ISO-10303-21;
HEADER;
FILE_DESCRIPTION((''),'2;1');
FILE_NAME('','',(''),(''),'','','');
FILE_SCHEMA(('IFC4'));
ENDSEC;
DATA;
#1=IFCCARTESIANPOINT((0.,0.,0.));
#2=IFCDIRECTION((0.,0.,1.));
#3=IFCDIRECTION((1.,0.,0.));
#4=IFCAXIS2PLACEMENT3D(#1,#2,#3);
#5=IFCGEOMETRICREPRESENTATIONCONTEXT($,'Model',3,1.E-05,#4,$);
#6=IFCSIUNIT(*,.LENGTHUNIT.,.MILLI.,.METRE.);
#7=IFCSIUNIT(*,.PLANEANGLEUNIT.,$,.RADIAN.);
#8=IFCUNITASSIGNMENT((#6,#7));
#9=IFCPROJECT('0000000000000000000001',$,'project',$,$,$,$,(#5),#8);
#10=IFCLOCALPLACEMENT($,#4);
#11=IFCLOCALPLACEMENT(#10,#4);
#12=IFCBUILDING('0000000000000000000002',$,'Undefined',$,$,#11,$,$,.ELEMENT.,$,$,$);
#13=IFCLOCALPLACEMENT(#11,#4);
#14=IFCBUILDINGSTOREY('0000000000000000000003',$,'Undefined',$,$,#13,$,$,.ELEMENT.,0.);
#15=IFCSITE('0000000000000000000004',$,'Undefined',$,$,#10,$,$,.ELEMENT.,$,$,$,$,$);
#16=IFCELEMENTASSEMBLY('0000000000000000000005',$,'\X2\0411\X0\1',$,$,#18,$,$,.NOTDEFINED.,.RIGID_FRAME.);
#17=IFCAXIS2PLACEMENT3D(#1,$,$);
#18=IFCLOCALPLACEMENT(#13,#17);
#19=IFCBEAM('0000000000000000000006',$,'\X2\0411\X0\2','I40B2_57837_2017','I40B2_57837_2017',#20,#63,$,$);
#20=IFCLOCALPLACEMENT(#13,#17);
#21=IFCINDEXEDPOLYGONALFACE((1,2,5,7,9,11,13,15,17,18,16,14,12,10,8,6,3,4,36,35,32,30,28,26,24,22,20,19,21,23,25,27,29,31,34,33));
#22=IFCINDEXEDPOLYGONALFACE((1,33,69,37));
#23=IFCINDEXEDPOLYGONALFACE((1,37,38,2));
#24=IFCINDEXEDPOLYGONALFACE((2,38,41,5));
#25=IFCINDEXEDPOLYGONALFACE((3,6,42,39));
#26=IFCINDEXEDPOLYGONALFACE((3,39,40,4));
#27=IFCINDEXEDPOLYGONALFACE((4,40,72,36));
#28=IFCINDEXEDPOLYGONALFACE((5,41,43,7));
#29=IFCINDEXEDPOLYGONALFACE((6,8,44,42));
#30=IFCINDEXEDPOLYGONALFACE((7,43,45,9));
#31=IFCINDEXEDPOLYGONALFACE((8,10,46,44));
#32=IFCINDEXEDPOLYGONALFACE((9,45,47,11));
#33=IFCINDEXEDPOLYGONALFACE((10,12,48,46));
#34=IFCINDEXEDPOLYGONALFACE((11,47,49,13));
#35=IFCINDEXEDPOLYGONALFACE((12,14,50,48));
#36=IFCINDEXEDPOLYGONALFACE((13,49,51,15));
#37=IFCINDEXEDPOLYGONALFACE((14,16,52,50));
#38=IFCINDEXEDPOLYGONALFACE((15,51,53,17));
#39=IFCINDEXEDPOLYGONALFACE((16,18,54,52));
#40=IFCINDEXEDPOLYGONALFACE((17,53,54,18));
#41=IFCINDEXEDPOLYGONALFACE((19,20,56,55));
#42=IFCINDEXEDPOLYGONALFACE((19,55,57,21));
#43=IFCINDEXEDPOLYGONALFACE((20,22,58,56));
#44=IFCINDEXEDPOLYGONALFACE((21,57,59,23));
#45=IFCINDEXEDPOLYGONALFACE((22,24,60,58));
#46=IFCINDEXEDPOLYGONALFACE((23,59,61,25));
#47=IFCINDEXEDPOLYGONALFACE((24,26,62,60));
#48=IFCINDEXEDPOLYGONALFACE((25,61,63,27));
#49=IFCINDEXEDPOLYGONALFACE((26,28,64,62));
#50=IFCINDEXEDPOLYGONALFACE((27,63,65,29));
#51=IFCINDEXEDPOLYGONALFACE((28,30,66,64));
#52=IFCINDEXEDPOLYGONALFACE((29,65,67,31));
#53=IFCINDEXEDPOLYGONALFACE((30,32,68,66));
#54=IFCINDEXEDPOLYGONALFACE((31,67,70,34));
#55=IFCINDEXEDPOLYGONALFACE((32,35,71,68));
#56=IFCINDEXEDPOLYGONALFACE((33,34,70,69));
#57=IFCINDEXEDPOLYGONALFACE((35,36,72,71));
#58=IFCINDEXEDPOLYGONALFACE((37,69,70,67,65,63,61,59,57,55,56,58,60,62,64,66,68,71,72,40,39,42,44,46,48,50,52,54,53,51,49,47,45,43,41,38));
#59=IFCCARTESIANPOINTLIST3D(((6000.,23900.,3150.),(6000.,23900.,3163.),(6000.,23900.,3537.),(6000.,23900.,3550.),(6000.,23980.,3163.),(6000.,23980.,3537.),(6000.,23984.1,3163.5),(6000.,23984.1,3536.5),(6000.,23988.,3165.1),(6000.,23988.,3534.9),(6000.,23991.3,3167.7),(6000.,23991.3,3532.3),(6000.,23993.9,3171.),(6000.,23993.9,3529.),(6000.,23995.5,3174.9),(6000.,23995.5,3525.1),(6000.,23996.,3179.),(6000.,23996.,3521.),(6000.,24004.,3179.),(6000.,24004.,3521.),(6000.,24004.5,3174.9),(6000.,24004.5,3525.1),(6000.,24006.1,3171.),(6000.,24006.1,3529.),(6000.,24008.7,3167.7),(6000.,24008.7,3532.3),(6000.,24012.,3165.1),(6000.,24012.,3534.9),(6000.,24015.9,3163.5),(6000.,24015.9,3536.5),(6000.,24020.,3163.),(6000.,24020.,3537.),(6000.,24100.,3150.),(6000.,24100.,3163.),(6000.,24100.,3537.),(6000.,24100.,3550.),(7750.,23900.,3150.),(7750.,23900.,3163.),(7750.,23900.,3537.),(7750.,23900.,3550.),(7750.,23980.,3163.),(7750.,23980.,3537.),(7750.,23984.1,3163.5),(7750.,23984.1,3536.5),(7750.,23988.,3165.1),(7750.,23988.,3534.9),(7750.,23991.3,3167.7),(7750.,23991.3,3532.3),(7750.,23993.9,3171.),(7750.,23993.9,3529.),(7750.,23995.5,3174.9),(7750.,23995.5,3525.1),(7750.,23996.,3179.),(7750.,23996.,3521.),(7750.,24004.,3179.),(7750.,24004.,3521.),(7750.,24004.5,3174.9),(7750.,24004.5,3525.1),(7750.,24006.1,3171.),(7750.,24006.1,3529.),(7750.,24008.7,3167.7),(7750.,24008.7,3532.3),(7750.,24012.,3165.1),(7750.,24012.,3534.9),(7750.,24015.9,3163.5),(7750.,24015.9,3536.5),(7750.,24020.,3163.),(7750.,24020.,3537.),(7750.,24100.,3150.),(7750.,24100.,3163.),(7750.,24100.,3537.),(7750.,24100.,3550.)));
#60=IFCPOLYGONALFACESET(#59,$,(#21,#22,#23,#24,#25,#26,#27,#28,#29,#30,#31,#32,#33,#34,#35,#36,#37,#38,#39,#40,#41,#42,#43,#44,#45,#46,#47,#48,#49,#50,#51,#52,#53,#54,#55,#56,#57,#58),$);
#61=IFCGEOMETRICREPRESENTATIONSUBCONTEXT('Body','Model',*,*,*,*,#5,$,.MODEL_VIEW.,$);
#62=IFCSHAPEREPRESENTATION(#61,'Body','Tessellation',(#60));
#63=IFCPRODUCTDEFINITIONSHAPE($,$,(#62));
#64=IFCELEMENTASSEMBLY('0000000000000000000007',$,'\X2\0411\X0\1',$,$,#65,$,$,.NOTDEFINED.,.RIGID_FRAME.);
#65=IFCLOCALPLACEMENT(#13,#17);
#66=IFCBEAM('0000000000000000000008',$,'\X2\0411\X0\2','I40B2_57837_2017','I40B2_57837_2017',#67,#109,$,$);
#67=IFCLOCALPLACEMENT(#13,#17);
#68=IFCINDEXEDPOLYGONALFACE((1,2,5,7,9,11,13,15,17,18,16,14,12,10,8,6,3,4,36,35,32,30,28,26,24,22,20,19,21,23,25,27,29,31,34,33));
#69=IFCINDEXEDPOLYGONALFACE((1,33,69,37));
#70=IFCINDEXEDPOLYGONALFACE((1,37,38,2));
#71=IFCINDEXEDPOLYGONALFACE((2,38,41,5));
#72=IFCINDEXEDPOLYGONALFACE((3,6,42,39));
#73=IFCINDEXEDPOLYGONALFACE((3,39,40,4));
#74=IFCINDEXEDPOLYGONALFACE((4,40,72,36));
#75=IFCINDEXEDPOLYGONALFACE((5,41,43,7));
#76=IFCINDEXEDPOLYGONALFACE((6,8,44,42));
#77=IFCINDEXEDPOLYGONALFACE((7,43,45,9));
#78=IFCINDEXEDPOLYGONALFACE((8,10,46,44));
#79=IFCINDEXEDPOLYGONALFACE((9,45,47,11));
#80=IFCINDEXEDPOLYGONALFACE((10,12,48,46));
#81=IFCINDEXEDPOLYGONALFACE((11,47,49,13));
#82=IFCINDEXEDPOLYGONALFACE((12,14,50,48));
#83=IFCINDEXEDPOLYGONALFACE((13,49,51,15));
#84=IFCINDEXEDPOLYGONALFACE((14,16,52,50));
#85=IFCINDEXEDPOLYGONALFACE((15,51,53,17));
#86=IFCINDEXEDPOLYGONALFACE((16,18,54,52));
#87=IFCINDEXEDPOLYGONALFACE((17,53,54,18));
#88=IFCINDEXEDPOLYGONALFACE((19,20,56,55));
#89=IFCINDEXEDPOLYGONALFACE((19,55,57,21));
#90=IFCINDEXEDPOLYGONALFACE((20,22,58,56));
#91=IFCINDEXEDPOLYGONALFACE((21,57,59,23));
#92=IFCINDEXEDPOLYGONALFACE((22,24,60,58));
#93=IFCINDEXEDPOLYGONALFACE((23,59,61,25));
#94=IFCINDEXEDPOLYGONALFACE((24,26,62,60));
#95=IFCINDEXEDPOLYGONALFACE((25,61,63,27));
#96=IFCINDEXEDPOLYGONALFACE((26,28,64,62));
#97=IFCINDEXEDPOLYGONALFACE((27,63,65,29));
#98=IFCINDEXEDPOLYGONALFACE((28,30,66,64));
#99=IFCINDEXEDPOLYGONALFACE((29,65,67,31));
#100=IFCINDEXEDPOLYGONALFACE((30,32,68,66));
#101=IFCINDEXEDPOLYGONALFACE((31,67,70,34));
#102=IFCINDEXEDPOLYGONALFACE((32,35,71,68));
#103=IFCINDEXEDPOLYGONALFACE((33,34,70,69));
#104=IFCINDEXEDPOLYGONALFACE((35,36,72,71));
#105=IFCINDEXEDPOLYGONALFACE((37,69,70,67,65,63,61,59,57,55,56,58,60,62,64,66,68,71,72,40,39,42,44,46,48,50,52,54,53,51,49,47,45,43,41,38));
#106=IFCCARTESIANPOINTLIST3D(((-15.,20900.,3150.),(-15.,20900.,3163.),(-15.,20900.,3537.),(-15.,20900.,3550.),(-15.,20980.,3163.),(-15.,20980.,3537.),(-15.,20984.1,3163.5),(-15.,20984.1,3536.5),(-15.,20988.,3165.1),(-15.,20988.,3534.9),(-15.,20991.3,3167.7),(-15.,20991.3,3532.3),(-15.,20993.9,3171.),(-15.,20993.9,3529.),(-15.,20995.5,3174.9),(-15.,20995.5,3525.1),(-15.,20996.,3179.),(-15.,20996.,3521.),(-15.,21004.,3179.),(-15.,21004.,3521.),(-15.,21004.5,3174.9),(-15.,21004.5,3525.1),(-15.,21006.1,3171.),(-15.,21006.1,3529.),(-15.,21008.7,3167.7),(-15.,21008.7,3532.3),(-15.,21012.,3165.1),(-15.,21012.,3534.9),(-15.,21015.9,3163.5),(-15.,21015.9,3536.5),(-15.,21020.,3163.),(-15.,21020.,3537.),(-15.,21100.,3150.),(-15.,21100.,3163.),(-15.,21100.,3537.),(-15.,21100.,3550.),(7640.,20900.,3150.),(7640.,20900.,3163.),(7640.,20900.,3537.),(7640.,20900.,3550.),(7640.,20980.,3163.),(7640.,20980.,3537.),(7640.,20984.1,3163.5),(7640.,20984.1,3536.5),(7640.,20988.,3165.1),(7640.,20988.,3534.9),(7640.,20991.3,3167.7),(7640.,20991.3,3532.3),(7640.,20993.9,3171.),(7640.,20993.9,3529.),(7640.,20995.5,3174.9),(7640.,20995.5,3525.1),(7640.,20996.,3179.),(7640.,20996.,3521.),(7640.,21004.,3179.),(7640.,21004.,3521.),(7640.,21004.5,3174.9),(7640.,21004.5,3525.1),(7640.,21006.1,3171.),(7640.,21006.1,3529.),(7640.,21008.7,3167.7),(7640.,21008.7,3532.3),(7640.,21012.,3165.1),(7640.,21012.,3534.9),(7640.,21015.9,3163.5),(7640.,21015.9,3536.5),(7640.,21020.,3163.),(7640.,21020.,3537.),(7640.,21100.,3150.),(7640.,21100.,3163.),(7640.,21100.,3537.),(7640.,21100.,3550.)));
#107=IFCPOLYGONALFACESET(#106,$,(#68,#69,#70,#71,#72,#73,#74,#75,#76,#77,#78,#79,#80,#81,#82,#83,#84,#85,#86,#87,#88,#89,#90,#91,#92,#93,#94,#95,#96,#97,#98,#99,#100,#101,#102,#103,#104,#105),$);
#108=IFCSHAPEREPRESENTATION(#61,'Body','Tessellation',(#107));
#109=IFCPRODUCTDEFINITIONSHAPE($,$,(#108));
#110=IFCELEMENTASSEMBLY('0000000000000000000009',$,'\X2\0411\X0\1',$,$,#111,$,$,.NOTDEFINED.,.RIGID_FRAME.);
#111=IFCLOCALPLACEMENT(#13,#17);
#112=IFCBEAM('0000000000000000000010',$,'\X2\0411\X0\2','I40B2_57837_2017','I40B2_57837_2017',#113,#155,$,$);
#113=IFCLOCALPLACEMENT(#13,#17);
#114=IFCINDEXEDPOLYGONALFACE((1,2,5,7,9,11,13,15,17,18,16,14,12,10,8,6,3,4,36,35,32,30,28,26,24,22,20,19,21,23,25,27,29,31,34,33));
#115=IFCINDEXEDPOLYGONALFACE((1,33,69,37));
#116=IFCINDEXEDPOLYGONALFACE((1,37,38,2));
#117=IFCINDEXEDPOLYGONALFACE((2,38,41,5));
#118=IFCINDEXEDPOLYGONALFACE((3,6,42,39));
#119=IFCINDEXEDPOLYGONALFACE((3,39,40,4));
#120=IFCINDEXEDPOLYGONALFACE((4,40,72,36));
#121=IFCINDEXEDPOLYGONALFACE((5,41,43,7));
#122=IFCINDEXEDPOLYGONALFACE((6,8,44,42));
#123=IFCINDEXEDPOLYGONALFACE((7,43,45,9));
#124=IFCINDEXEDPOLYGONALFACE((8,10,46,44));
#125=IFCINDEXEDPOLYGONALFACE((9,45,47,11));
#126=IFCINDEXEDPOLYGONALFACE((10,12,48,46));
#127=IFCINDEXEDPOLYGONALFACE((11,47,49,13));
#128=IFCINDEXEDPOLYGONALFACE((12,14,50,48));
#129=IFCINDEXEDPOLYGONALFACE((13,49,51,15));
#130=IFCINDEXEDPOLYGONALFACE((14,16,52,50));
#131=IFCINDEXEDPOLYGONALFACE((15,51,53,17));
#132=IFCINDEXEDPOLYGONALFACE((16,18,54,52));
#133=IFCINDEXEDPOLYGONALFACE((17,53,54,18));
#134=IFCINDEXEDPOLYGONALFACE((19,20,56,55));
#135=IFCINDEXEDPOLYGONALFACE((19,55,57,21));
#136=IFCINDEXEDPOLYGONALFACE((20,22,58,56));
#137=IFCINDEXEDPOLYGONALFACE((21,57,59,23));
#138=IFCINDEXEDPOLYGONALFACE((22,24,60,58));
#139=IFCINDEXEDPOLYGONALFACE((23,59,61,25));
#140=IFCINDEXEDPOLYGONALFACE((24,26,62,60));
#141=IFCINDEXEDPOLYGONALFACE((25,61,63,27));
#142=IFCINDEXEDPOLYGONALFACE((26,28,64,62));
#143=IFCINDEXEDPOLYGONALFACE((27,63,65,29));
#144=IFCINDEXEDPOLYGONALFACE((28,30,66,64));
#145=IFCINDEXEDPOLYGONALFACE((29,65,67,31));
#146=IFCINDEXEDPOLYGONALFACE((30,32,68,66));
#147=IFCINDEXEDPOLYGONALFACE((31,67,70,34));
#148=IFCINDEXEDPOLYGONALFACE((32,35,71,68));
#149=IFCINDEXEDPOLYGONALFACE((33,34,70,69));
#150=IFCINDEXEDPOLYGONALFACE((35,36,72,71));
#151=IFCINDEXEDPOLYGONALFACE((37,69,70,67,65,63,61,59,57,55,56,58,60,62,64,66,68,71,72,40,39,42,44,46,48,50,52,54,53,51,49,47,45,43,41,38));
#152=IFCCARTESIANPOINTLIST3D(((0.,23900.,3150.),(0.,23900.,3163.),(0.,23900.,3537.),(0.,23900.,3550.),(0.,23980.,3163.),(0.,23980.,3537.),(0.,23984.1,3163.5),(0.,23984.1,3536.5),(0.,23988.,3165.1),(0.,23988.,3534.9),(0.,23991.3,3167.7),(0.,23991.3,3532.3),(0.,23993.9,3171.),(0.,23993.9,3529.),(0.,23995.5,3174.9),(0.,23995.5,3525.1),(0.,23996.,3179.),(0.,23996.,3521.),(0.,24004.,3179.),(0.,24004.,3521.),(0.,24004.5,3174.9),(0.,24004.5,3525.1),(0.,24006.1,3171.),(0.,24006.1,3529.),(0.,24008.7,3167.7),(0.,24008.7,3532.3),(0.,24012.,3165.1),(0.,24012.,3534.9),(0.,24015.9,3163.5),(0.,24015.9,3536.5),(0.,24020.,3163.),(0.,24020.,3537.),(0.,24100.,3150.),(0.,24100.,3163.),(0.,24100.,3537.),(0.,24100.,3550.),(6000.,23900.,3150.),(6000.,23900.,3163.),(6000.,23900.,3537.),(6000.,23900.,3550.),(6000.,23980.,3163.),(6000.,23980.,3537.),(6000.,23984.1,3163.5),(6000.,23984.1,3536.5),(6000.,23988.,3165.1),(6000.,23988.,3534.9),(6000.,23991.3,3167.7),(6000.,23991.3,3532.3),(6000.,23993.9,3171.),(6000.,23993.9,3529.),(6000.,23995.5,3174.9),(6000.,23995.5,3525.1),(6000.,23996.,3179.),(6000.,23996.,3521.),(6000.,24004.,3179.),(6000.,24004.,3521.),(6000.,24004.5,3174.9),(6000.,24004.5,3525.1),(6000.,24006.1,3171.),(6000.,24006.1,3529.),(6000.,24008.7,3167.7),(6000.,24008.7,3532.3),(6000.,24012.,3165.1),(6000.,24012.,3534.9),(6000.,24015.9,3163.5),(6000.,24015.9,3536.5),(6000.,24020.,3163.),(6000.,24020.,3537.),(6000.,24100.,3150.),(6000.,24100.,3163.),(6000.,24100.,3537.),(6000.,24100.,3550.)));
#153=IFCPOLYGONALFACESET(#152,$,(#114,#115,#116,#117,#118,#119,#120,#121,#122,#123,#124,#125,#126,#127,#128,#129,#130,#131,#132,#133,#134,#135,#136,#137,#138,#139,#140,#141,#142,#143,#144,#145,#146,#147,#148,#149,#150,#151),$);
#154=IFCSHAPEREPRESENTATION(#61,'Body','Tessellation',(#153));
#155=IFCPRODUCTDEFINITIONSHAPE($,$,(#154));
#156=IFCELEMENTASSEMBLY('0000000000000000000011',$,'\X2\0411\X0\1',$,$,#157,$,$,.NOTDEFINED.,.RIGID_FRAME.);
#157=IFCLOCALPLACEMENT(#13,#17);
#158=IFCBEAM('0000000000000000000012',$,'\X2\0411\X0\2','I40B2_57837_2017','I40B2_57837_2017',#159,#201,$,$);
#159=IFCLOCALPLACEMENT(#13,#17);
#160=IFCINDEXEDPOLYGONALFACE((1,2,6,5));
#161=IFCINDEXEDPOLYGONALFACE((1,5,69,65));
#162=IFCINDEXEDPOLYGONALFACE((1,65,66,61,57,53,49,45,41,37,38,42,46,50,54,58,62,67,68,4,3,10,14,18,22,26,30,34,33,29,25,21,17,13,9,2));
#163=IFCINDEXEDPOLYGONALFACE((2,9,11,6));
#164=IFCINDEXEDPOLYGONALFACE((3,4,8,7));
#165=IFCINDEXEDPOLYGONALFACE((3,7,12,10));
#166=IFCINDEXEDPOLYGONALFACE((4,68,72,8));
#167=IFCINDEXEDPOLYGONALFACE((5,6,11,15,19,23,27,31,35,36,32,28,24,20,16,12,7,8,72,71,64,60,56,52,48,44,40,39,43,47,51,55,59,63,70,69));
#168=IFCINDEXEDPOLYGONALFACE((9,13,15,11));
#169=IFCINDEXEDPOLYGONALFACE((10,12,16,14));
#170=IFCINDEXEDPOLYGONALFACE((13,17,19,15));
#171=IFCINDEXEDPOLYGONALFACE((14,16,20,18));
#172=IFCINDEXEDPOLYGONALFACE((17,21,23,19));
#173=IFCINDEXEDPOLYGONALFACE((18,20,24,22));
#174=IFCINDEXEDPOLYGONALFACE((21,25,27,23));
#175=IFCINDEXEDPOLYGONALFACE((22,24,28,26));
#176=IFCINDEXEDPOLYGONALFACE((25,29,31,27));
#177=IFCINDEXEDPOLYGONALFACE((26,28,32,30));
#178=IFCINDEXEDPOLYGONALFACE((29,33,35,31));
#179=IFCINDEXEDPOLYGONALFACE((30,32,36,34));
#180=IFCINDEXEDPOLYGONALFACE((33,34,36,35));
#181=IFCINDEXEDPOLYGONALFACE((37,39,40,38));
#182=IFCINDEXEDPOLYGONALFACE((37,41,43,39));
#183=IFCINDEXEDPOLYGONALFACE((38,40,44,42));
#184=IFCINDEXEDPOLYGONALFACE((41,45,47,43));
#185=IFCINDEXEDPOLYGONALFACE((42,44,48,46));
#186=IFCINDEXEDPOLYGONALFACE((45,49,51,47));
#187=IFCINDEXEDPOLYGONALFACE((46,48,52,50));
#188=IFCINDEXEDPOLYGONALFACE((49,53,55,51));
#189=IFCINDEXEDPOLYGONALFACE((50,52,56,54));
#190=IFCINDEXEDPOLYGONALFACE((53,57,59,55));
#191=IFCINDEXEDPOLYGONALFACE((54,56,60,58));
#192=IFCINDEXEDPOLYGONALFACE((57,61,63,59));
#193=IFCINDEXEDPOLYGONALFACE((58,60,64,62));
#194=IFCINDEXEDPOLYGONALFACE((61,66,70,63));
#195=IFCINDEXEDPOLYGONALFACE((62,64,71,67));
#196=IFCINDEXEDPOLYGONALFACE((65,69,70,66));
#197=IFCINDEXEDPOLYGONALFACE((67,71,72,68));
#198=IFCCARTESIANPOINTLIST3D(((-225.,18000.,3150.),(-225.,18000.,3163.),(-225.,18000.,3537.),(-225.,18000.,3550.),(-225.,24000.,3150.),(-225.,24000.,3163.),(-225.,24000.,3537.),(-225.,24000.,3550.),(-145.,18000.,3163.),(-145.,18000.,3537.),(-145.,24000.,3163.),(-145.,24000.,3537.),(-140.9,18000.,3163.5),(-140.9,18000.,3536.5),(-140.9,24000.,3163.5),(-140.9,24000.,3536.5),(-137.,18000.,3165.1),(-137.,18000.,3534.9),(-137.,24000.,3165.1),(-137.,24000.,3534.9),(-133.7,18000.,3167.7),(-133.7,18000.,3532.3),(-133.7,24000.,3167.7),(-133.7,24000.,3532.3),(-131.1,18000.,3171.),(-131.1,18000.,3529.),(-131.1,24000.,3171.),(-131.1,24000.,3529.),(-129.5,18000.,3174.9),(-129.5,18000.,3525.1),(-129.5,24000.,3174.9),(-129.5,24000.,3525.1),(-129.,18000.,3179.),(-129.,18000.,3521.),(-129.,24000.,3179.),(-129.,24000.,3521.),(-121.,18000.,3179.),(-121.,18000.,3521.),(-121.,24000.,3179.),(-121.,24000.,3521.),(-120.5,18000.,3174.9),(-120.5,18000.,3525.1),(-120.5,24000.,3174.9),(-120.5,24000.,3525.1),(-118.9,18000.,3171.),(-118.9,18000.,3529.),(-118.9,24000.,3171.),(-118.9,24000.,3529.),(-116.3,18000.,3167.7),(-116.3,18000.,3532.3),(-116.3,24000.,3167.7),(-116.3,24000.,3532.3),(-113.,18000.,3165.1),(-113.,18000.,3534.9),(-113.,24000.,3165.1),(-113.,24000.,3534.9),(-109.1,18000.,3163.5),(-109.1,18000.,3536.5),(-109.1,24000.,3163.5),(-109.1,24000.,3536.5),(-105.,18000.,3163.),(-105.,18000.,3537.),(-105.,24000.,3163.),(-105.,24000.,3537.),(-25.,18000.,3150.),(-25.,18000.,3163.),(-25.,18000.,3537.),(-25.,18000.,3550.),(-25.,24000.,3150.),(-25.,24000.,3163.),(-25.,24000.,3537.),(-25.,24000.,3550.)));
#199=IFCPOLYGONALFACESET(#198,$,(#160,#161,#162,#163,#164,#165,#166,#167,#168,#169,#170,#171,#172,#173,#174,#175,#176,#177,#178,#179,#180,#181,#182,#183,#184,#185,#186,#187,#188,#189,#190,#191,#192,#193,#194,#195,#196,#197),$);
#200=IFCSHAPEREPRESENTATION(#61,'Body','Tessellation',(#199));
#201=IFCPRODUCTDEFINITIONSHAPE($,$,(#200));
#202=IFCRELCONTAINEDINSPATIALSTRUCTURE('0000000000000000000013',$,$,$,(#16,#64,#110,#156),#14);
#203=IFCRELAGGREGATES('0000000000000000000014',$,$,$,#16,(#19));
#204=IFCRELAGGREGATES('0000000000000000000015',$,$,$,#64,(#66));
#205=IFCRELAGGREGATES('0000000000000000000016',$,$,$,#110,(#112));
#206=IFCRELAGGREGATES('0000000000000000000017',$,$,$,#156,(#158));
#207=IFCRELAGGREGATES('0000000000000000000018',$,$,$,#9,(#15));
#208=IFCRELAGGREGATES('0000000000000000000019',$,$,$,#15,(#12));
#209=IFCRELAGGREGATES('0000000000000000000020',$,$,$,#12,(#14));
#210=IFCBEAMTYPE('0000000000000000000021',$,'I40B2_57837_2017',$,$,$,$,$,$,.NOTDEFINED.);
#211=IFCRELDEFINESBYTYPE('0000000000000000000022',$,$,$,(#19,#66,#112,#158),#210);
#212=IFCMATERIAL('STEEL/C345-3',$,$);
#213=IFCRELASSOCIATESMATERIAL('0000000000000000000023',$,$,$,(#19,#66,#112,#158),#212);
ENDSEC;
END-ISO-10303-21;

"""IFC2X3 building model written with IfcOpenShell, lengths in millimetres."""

from ifc_helpers import new_model, si_unit, frame, origin_with_axes, origin_2d_with_axis, place, context, subcontext, project, spatial, i_section, extrude, material, type_object, element, aggregate, save


model = new_model("IFC2X3")

# Units and contexts
model_context = context("Model", 3, precision=1e-05, world=origin_with_axes())
body_context = subcontext(model_context, "Body", "Model", "MODEL_VIEW")
ifc_project = project(units=[si_unit("LENGTHUNIT", "METRE", prefix="MILLI"), si_unit("PLANEANGLEUNIT", "RADIAN")], contexts=[model_context])

# Site, building, storey
site_placement = place(None, origin_with_axes())
site = spatial("IfcSite", under=ifc_project, at=site_placement, Name="Undefined", CompositionType="ELEMENT")
building_placement = place(site_placement, origin_with_axes())
building = spatial("IfcBuilding", under=site, at=building_placement, Name="Undefined", CompositionType="ELEMENT")
storey_placement = place(building_placement, origin_with_axes())
storey = spatial("IfcBuildingStorey", under=building, at=storey_placement, Name="Undefined", CompositionType="ELEMENT", Elevation=0.0)

# Element assemblies, beams
assembly_1_placement = place(storey_placement, origin_with_axes())
assembly_1 = element("IfcElementAssembly", 1, at=assembly_1_placement, inside=storey, Name="Б1", AssemblyPlace="NOTDEFINED", PredefinedType="RIGID_FRAME")
ifc_material_1 = material(Name="STEEL/C345-3")
beam_type_1 = type_object("IfcBeamType", Name="I40B2_57837_2017", PredefinedType="NOTDEFINED")
beam_1_placement = place(assembly_1_placement, frame((6000.0, 24000.0, 3350.0), z_axis=(0.0, 0.0, -1.0), x_axis=(1.0, 0.0, 0.0)))
beam_1 = element("IfcBeam", 2, at=beam_1_placement, type_object=beam_type_1, material=ifc_material_1, Name="Б2", Description="I40B2_57837_2017", ObjectType="I40B2_57837_2017", context=body_context, shape_type="SweptSolid", body=[
    extrude(i_section(OverallWidth=200.0, OverallDepth=400.0, WebThickness=8.0, FlangeThickness=13.0, FilletRadius=16.0, at=origin_2d_with_axis()), frame((1750.0, 0.0, 0.0), z_axis=(-1.0, 0.0, 0.0), x_axis=(0.0, -1.0, 0.0)), (0.0, 0.0, 1.0), 1750.0),
])
aggregate(assembly_1, [beam_1])
assembly_2_placement = place(storey_placement, origin_with_axes())
assembly_2 = element("IfcElementAssembly", 3, at=assembly_2_placement, inside=storey, Name="Б1", AssemblyPlace="NOTDEFINED", PredefinedType="RIGID_FRAME")
beam_2_placement = place(assembly_2_placement, frame((-15.0, 21000.0, 3350.0), z_axis=(0.0, 0.0, -1.0), x_axis=(1.0, 0.0, 0.0)))
beam_2 = element("IfcBeam", 4, at=beam_2_placement, type_object=beam_type_1, material=ifc_material_1, Name="Б2", Description="I40B2_57837_2017", ObjectType="I40B2_57837_2017", context=body_context, shape_type="SweptSolid", body=[
    extrude(i_section(OverallWidth=200.0, OverallDepth=400.0, WebThickness=8.0, FlangeThickness=13.0, FilletRadius=16.0, at=origin_2d_with_axis()), frame((7655.0, 0.0, 0.0), z_axis=(-1.0, 0.0, 0.0), x_axis=(0.0, -1.0, 0.0)), (0.0, 0.0, 1.0), 7655.0),
])
aggregate(assembly_2, [beam_2])
assembly_3_placement = place(storey_placement, origin_with_axes())
assembly_3 = element("IfcElementAssembly", 5, at=assembly_3_placement, inside=storey, Name="Б1", AssemblyPlace="NOTDEFINED", PredefinedType="RIGID_FRAME")
beam_3_placement = place(assembly_3_placement, frame((0.0, 24000.0, 3350.0), z_axis=(0.0, 0.0, -1.0), x_axis=(1.0, 0.0, 0.0)))
beam_3 = element("IfcBeam", 6, at=beam_3_placement, type_object=beam_type_1, material=ifc_material_1, Name="Б2", Description="I40B2_57837_2017", ObjectType="I40B2_57837_2017", context=body_context, shape_type="SweptSolid", body=[
    extrude(i_section(OverallWidth=200.0, OverallDepth=400.0, WebThickness=8.0, FlangeThickness=13.0, FilletRadius=16.0, at=origin_2d_with_axis()), frame((6000.0, 0.0, 0.0), z_axis=(-1.0, 0.0, 0.0), x_axis=(0.0, -1.0, 0.0)), (0.0, 0.0, 1.0), 6000.0),
])
aggregate(assembly_3, [beam_3])
assembly_4_placement = place(storey_placement, origin_with_axes())
assembly_4 = element("IfcElementAssembly", 7, at=assembly_4_placement, inside=storey, Name="Б1", AssemblyPlace="NOTDEFINED", PredefinedType="RIGID_FRAME")
beam_4_placement = place(assembly_4_placement, frame((-125.0, 24000.0, 3350.0), z_axis=(0.0, 0.0, -1.0), x_axis=(0.0, -1.0, 0.0)))
beam_4 = element("IfcBeam", 8, at=beam_4_placement, type_object=beam_type_1, material=ifc_material_1, Name="Б2", Description="I40B2_57837_2017", ObjectType="I40B2_57837_2017", context=body_context, shape_type="SweptSolid", body=[
    extrude(i_section(OverallWidth=200.0, OverallDepth=400.0, WebThickness=8.0, FlangeThickness=13.0, FilletRadius=16.0, at=origin_2d_with_axis()), frame((6000.0, 0.0, 0.0), z_axis=(-1.0, 0.0, 0.0), x_axis=(0.0, -1.0, 0.0)), (0.0, 0.0, 1.0), 6000.0),
])
aggregate(assembly_4, [beam_4])

save(model, "model.ifc")
